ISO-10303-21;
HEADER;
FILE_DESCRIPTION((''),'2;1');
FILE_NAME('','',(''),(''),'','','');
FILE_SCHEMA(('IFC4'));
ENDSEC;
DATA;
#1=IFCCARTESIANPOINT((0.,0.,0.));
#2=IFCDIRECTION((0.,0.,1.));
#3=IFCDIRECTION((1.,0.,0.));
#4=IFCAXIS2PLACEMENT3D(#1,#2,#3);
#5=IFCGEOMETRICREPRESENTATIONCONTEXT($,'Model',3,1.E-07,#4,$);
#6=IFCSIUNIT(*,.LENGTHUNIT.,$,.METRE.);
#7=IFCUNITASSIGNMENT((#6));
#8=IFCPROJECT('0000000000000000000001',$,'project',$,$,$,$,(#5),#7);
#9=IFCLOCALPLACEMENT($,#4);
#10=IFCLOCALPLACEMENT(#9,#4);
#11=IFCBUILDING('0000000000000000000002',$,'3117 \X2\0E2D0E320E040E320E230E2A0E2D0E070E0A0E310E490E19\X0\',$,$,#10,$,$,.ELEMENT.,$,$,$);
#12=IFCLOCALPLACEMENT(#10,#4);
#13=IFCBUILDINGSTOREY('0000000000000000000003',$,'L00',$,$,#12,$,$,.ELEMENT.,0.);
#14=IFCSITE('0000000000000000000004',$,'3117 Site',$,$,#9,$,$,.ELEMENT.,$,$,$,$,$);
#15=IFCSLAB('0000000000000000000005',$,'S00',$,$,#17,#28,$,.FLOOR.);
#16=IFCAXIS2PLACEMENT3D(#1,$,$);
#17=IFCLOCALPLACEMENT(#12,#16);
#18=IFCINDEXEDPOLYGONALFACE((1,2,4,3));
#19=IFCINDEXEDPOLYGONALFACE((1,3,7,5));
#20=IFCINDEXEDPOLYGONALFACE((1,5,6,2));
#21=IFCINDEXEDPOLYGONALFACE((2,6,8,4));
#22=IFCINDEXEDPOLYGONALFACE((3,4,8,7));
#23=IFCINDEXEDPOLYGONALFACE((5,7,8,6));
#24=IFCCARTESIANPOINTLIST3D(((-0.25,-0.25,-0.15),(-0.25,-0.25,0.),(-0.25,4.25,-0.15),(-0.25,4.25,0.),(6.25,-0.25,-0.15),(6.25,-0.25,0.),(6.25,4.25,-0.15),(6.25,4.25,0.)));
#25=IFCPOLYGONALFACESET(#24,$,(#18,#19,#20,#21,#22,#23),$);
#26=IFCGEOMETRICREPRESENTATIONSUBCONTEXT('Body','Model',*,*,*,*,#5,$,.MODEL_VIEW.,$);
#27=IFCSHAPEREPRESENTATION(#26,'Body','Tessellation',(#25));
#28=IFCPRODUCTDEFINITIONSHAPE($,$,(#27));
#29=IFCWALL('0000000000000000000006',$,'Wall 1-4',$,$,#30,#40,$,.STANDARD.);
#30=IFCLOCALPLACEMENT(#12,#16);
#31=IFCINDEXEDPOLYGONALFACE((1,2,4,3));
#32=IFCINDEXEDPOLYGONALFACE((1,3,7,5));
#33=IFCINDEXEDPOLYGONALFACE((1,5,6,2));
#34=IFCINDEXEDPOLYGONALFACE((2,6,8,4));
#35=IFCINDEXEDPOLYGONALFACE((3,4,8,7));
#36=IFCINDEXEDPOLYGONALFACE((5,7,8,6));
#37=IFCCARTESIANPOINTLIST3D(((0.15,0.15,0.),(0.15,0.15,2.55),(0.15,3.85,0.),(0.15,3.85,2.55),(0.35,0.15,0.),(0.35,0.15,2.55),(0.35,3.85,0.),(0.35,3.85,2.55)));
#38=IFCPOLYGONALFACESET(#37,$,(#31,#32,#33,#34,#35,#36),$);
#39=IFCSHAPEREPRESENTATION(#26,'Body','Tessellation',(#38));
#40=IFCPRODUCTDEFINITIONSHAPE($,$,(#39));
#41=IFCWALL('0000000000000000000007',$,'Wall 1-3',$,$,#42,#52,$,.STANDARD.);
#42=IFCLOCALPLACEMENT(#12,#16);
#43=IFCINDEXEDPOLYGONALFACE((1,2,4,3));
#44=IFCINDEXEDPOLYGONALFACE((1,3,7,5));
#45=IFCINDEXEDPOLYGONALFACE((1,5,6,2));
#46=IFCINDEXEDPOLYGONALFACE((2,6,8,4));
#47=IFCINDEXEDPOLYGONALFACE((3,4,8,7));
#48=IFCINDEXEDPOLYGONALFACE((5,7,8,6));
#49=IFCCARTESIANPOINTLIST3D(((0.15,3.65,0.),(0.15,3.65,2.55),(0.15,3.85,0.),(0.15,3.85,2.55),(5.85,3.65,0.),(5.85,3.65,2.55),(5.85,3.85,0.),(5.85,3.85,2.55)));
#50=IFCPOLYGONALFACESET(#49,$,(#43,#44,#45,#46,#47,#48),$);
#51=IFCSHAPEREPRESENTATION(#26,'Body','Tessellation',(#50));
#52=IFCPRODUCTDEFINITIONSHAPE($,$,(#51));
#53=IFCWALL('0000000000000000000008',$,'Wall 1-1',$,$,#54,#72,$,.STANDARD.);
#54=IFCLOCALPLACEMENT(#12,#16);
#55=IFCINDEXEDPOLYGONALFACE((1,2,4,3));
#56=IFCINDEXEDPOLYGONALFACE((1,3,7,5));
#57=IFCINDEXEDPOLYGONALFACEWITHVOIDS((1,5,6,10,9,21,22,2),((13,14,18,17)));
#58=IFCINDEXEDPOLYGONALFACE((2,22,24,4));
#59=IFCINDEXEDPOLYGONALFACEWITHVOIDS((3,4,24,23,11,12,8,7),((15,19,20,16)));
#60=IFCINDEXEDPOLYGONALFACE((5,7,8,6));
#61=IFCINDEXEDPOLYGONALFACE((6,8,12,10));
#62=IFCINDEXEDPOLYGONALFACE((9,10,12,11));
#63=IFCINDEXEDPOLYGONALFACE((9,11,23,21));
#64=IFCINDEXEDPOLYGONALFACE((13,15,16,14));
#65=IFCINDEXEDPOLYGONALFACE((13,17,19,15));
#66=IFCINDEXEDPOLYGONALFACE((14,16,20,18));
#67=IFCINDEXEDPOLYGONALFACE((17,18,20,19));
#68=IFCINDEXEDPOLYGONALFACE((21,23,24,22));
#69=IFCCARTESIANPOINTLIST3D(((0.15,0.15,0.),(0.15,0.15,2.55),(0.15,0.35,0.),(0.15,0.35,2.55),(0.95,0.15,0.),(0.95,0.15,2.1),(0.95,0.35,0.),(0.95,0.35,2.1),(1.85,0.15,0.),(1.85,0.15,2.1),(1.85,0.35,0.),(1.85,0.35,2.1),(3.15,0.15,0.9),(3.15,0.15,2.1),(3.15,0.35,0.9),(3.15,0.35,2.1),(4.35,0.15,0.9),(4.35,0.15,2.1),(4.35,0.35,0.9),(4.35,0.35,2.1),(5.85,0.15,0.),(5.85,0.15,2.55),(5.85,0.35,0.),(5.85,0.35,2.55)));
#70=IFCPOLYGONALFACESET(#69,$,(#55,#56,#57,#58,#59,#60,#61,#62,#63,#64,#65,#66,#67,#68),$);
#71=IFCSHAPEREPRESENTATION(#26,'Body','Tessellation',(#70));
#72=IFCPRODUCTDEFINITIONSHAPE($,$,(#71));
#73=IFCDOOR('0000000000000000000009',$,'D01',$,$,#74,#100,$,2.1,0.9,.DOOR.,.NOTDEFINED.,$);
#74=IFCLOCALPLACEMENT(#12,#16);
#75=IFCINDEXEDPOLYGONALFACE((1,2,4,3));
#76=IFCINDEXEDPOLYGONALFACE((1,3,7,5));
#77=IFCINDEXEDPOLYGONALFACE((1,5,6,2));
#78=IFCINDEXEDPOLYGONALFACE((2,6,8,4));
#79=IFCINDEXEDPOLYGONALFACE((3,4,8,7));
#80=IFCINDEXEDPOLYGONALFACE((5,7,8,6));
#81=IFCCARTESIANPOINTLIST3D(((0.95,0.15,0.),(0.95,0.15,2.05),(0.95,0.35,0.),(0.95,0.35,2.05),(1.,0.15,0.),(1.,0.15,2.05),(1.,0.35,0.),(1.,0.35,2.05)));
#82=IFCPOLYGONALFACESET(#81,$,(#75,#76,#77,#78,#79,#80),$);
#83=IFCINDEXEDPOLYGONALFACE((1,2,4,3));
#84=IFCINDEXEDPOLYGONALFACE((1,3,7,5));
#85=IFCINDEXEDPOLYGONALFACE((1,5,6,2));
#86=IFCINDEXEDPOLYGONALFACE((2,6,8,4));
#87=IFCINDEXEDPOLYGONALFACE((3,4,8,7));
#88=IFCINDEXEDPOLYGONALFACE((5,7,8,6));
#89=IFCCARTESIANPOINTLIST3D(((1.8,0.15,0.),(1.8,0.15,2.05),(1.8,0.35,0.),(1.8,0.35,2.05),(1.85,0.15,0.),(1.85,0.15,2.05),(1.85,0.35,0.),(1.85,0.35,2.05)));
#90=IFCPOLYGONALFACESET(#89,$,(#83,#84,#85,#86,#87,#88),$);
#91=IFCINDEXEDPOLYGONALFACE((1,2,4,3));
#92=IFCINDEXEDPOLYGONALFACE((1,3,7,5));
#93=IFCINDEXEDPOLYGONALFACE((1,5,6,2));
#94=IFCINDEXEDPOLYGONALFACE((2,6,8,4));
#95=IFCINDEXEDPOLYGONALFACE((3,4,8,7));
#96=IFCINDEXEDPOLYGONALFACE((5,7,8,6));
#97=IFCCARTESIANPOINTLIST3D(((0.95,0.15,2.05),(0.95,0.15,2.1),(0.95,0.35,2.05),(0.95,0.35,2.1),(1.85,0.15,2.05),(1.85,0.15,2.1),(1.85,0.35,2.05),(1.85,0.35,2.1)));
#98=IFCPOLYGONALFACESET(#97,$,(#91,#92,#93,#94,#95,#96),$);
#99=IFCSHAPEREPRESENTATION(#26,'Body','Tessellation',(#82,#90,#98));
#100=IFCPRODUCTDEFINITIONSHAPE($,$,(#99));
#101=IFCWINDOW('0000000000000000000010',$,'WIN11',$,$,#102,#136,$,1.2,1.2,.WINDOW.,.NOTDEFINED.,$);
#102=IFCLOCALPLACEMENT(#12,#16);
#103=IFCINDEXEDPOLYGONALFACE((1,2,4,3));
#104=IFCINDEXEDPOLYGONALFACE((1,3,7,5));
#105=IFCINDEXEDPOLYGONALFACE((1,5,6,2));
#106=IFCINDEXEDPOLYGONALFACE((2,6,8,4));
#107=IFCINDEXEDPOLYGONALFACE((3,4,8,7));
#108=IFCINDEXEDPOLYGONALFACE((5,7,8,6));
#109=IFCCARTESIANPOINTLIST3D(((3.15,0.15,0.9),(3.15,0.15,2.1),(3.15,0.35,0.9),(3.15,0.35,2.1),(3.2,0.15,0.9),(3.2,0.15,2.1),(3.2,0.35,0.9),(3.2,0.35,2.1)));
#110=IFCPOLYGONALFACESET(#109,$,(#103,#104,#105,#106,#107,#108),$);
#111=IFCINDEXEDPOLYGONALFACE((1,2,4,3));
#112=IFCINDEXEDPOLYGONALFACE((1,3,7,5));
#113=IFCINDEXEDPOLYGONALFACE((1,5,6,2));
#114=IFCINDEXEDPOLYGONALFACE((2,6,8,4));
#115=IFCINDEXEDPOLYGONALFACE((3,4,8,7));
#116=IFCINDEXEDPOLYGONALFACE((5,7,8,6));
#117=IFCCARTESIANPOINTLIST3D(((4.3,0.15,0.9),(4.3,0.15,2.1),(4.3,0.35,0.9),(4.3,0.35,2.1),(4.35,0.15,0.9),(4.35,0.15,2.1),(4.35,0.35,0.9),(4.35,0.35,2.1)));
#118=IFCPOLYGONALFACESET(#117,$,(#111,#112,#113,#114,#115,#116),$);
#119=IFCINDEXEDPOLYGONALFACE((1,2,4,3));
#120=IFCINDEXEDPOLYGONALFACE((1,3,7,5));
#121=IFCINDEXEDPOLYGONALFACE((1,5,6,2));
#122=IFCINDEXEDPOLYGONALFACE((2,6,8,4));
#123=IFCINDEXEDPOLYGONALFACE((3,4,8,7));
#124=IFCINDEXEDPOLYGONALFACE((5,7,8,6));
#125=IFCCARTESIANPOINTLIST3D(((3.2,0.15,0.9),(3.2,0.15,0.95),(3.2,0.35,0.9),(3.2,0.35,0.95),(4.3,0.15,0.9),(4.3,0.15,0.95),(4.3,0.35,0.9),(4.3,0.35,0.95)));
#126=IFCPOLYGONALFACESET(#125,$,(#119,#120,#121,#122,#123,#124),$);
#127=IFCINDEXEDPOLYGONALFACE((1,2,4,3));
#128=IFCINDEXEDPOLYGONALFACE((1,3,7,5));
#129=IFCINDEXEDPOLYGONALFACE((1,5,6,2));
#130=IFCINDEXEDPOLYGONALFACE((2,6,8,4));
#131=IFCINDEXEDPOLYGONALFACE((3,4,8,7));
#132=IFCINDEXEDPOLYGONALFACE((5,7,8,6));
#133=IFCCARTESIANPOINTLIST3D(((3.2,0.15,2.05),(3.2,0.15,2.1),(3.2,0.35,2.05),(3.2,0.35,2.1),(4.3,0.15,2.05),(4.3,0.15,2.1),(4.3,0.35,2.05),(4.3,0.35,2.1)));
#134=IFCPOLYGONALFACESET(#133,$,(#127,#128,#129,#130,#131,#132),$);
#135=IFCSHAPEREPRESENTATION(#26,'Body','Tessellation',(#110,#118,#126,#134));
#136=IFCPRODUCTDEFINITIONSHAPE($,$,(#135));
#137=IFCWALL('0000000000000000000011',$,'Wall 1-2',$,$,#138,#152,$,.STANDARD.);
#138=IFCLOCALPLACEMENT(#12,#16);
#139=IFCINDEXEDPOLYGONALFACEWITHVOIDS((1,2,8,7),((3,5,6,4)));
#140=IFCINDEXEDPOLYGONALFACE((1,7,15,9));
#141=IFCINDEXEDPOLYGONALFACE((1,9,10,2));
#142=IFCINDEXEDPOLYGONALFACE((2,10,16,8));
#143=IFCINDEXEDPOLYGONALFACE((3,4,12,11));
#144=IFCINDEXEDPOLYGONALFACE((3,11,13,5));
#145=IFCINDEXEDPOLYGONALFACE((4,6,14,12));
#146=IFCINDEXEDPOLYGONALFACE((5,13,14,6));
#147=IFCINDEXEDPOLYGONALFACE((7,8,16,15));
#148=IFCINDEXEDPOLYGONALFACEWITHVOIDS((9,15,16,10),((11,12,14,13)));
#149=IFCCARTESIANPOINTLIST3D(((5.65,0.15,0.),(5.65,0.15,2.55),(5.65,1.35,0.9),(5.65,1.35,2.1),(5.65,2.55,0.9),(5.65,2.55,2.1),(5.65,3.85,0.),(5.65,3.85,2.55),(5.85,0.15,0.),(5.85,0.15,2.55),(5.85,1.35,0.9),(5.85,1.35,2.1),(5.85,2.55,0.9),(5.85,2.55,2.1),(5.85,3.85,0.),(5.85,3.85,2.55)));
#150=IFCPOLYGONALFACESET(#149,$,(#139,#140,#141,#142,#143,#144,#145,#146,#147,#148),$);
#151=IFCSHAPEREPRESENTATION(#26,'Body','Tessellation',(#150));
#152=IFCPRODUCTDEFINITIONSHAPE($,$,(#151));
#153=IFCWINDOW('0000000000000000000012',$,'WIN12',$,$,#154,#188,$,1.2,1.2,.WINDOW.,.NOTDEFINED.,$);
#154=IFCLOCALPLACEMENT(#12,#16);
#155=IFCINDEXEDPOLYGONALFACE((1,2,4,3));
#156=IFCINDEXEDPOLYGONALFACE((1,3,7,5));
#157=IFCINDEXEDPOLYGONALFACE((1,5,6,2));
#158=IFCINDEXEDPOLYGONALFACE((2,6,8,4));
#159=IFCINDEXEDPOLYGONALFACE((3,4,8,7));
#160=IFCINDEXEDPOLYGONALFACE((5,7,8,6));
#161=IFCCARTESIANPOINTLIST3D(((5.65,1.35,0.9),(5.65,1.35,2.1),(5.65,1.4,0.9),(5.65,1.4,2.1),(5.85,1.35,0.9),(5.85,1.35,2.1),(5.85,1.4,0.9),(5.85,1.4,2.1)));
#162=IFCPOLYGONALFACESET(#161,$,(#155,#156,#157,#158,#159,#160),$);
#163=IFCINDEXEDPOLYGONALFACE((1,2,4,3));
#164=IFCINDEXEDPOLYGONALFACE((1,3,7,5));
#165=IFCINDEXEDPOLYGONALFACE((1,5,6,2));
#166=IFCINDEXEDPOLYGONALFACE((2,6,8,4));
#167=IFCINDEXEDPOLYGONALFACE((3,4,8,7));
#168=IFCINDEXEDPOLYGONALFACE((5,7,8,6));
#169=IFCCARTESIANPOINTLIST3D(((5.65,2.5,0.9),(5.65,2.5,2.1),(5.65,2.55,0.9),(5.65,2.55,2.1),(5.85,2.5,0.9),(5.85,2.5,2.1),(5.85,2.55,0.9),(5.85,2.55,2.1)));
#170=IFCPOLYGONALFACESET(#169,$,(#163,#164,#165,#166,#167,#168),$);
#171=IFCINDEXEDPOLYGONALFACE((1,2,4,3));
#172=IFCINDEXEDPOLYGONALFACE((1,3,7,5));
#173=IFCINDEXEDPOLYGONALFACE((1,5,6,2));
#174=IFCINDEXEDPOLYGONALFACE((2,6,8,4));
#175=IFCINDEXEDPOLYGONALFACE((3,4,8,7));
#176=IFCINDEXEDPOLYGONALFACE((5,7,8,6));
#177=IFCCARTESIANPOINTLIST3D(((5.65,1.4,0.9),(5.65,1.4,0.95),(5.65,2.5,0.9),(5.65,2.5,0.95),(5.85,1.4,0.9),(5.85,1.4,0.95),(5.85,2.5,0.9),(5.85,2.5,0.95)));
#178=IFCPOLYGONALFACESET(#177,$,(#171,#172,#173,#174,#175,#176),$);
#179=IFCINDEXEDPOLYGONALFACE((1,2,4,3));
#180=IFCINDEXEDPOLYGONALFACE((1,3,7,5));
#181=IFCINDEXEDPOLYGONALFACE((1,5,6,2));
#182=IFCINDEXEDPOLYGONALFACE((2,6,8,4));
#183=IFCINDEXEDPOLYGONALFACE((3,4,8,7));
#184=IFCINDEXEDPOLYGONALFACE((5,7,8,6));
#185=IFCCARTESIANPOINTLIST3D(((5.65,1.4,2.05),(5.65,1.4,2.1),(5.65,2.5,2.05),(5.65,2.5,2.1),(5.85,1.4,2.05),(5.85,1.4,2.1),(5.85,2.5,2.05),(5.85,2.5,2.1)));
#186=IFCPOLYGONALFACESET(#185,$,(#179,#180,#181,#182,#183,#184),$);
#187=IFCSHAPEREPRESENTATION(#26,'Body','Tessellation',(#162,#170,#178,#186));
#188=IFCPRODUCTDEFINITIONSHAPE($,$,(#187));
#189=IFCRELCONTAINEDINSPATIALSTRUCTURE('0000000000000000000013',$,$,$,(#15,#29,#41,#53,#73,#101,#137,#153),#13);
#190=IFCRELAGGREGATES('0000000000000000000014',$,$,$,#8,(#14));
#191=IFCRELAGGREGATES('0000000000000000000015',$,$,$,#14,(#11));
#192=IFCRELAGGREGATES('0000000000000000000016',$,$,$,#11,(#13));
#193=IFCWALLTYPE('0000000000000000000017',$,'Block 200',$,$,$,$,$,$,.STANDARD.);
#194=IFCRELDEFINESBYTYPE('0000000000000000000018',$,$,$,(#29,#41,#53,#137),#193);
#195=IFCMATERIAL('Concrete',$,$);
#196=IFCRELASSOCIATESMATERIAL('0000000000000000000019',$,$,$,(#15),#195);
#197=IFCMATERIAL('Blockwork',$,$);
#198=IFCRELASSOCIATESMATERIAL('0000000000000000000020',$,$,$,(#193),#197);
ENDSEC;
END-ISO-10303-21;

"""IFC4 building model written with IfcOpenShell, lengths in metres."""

from ifc_helpers import new_model, si_unit, frame, origin_with_axes, place, context, subcontext, project, spatial, polyline, outline, extrude, material, type_object, element, fill, save


model = new_model("IFC4")

# Units and contexts
model_context = context("Model", 3, precision=1e-07, world=origin_with_axes())
body_context = subcontext(model_context, "Body", "Model", "MODEL_VIEW")
ifc_project = project(units=[si_unit("LENGTHUNIT", "METRE")], contexts=[model_context])

# Site, building, storey
site_placement = place(None, origin_with_axes())
site = spatial("IfcSite", under=ifc_project, at=site_placement, Name="3117 Site", CompositionType="ELEMENT")
building_placement = place(site_placement, origin_with_axes())
building = spatial("IfcBuilding", under=site, at=building_placement, Name="3117 อาคารสองชั้น", CompositionType="ELEMENT")
storey_placement = place(building_placement, origin_with_axes())
storey = spatial("IfcBuildingStorey", under=building, at=storey_placement, Name="L00", CompositionType="ELEMENT", Elevation=0.0)

# Slab
ifc_material_1 = material(Name="Concrete")
slab_placement = place(storey_placement, frame((0.0, 0.0, -0.15), z_axis=(0.0, 0.0, 1.0), x_axis=(1.0, 0.0, 0.0)))
element("IfcSlab", 1, at=slab_placement, inside=storey, material=ifc_material_1, Name="S00", PredefinedType="FLOOR", context=body_context, shape_type="SweptSolid", body=[
    extrude(outline(polyline([(-0.25, -0.25), (6.25, -0.25), (6.25, 4.25), (-0.25, 4.25), (-0.25, -0.25)])), origin_with_axes(), (0.0, 0.0, 1.0), 0.15),
])

# Walls
ifc_material_2 = material(Name="Blockwork")
wall_type = type_object("IfcWallType", Name="Block 200", PredefinedType="STANDARD", material=ifc_material_2)
wall_1_placement = place(storey_placement, frame((0.15, 3.85, 0.0), z_axis=(0.0, 0.0, 1.0), x_axis=(0.0, -1.0, 0.0)))
element("IfcWall", 2, at=wall_1_placement, inside=storey, type_object=wall_type, Name="Wall 1-4", PredefinedType="STANDARD", context=body_context, shape_type="SweptSolid", body=[
    extrude(outline(polyline([(0.0, 0.0), (3.7, 0.0), (3.7, 0.2), (0.0, 0.2), (0.0, 0.0)])), origin_with_axes(), (0.0, 0.0, 1.0), 2.55),
])
wall_2_placement = place(storey_placement, frame((5.85, 3.85, 0.0), z_axis=(0.0, 0.0, 1.0), x_axis=(-1.0, 0.0, 0.0)))
element("IfcWall", 3, at=wall_2_placement, inside=storey, type_object=wall_type, Name="Wall 1-3", PredefinedType="STANDARD", context=body_context, shape_type="SweptSolid", body=[
    extrude(outline(polyline([(0.0, 0.0), (5.7, 0.0), (5.7, 0.2), (0.0, 0.2), (0.0, 0.0)])), origin_with_axes(), (0.0, 0.0, 1.0), 2.55),
])

# Wall, openings, door, window
wall_3_placement = place(storey_placement, frame((0.15, 0.15, 0.0), z_axis=(0.0, 0.0, 1.0), x_axis=(1.0, 0.0, 0.0)))
wall_3 = element("IfcWall", 4, at=wall_3_placement, inside=storey, type_object=wall_type, Name="Wall 1-1", PredefinedType="STANDARD", context=body_context, shape_type="SweptSolid", body=[
    extrude(outline(polyline([(0.0, 0.0), (5.7, 0.0), (5.7, 0.2), (0.0, 0.2), (0.0, 0.0)])), origin_with_axes(), (0.0, 0.0, 1.0), 2.55),
])
opening_1_placement = place(wall_3_placement, frame((0.8, 0.0, 0.0), z_axis=(0.0, 0.0, 1.0), x_axis=(1.0, 0.0, 0.0)))
opening_1 = element("IfcOpeningElement", 5, at=opening_1_placement, cuts=wall_3, PredefinedType="OPENING", context=body_context, shape_type="SweptSolid", body=[
    extrude(outline(polyline([(0.0, 0.0), (0.9, 0.0), (0.9, 0.2), (0.0, 0.2), (0.0, 0.0)])), origin_with_axes(), (0.0, 0.0, 1.0), 2.1),
])
opening_2_placement = place(wall_3_placement, frame((3.0, 0.0, 0.9), z_axis=(0.0, 0.0, 1.0), x_axis=(1.0, 0.0, 0.0)))
opening_2 = element("IfcOpeningElement", 6, at=opening_2_placement, cuts=wall_3, PredefinedType="OPENING", context=body_context, shape_type="SweptSolid", body=[
    extrude(outline(polyline([(0.0, 0.0), (1.2, 0.0), (1.2, 0.2), (0.0, 0.2), (0.0, 0.0)])), origin_with_axes(), (0.0, 0.0, 1.0), 1.2),
])
door_placement = place(opening_1_placement, frame((0.0, 0.0, 0.0), z_axis=(0.0, 0.0, 1.0), x_axis=(1.0, 0.0, 0.0)))
door = element("IfcDoor", 7, at=door_placement, inside=storey, Name="D01", OperationType="NOTDEFINED", OverallHeight=2.1, OverallWidth=0.9, PredefinedType="DOOR", context=body_context, shape_type="SweptSolid", body=[
    extrude(outline(polyline([(0.0, 0.0), (0.05, 0.0), (0.05, 0.2), (0.0, 0.2), (0.0, 0.0)])), origin_with_axes(), (0.0, 0.0, 1.0), 2.05),
    extrude(outline(polyline([(0.0, 0.0), (0.05, 0.0), (0.05, 0.2), (0.0, 0.2), (0.0, 0.0)])), frame((0.85, 0.0, 0.0), z_axis=(0.0, 0.0, 1.0), x_axis=(1.0, 0.0, 0.0)), (0.0, 0.0, 1.0), 2.05),
    extrude(outline(polyline([(0.0, 0.0), (0.9, 0.0), (0.9, 0.2), (0.0, 0.2), (0.0, 0.0)])), frame((0.0, 0.0, 2.05), z_axis=(0.0, 0.0, 1.0), x_axis=(1.0, 0.0, 0.0)), (0.0, 0.0, 1.0), 0.05),
])
fill(opening_1, door)
window_1_placement = place(opening_2_placement, frame((0.0, 0.0, 0.0), z_axis=(0.0, 0.0, 1.0), x_axis=(1.0, 0.0, 0.0)))
window_1 = element("IfcWindow", 8, at=window_1_placement, inside=storey, Name="WIN11", OverallHeight=1.2, OverallWidth=1.2, PartitioningType="NOTDEFINED", PredefinedType="WINDOW", context=body_context, shape_type="SweptSolid", body=[
    extrude(outline(polyline([(0.0, 0.0), (0.05, 0.0), (0.05, 0.2), (0.0, 0.2), (0.0, 0.0)])), origin_with_axes(), (0.0, 0.0, 1.0), 1.2),
    extrude(outline(polyline([(0.0, 0.0), (0.05, 0.0), (0.05, 0.2), (0.0, 0.2), (0.0, 0.0)])), frame((1.15, 0.0, 0.0), z_axis=(0.0, 0.0, 1.0), x_axis=(1.0, 0.0, 0.0)), (0.0, 0.0, 1.0), 1.2),
    extrude(outline(polyline([(0.0, 0.0), (1.1, 0.0), (1.1, 0.2), (0.0, 0.2), (0.0, 0.0)])), frame((0.05, 0.0, 0.0), z_axis=(0.0, 0.0, 1.0), x_axis=(1.0, 0.0, 0.0)), (0.0, 0.0, 1.0), 0.05),
    extrude(outline(polyline([(0.0, 0.0), (1.1, 0.0), (1.1, 0.2), (0.0, 0.2), (0.0, 0.0)])), frame((0.05, 0.0, 1.15), z_axis=(0.0, 0.0, 1.0), x_axis=(1.0, 0.0, 0.0)), (0.0, 0.0, 1.0), 0.05),
])
fill(opening_2, window_1)

# Wall, opening, window
wall_4_placement = place(storey_placement, frame((5.85, 0.15, 0.0), z_axis=(0.0, 0.0, 1.0), x_axis=(0.0, 1.0, 0.0)))
wall_4 = element("IfcWall", 9, at=wall_4_placement, inside=storey, type_object=wall_type, Name="Wall 1-2", PredefinedType="STANDARD", context=body_context, shape_type="SweptSolid", body=[
    extrude(outline(polyline([(0.0, 0.0), (3.7, 0.0), (3.7, 0.2), (0.0, 0.2), (0.0, 0.0)])), origin_with_axes(), (0.0, 0.0, 1.0), 2.55),
])
opening_3_placement = place(wall_4_placement, frame((1.2, 0.0, 0.9), z_axis=(0.0, 0.0, 1.0), x_axis=(1.0, 0.0, 0.0)))
opening_3 = element("IfcOpeningElement", 10, at=opening_3_placement, cuts=wall_4, PredefinedType="OPENING", context=body_context, shape_type="SweptSolid", body=[
    extrude(outline(polyline([(0.0, 0.0), (1.2, 0.0), (1.2, 0.2), (0.0, 0.2), (0.0, 0.0)])), origin_with_axes(), (0.0, 0.0, 1.0), 1.2),
])
window_2_placement = place(opening_3_placement, frame((0.0, 0.0, 0.0), z_axis=(0.0, 0.0, 1.0), x_axis=(1.0, 0.0, 0.0)))
window_2 = element("IfcWindow", 11, at=window_2_placement, inside=storey, Name="WIN12", OverallHeight=1.2, OverallWidth=1.2, PartitioningType="NOTDEFINED", PredefinedType="WINDOW", context=body_context, shape_type="SweptSolid", body=[
    extrude(outline(polyline([(0.0, 0.0), (0.05, 0.0), (0.05, 0.2), (0.0, 0.2), (0.0, 0.0)])), origin_with_axes(), (0.0, 0.0, 1.0), 1.2),
    extrude(outline(polyline([(0.0, 0.0), (0.05, 0.0), (0.05, 0.2), (0.0, 0.2), (0.0, 0.0)])), frame((1.15, 0.0, 0.0), z_axis=(0.0, 0.0, 1.0), x_axis=(1.0, 0.0, 0.0)), (0.0, 0.0, 1.0), 1.2),
    extrude(outline(polyline([(0.0, 0.0), (1.1, 0.0), (1.1, 0.2), (0.0, 0.2), (0.0, 0.0)])), frame((0.05, 0.0, 0.0), z_axis=(0.0, 0.0, 1.0), x_axis=(1.0, 0.0, 0.0)), (0.0, 0.0, 1.0), 0.05),
    extrude(outline(polyline([(0.0, 0.0), (1.1, 0.0), (1.1, 0.2), (0.0, 0.2), (0.0, 0.0)])), frame((0.05, 0.0, 1.15), z_axis=(0.0, 0.0, 1.0), x_axis=(1.0, 0.0, 0.0)), (0.0, 0.0, 1.0), 0.05),
])
fill(opening_3, window_2)

save(model, "model.ifc")
